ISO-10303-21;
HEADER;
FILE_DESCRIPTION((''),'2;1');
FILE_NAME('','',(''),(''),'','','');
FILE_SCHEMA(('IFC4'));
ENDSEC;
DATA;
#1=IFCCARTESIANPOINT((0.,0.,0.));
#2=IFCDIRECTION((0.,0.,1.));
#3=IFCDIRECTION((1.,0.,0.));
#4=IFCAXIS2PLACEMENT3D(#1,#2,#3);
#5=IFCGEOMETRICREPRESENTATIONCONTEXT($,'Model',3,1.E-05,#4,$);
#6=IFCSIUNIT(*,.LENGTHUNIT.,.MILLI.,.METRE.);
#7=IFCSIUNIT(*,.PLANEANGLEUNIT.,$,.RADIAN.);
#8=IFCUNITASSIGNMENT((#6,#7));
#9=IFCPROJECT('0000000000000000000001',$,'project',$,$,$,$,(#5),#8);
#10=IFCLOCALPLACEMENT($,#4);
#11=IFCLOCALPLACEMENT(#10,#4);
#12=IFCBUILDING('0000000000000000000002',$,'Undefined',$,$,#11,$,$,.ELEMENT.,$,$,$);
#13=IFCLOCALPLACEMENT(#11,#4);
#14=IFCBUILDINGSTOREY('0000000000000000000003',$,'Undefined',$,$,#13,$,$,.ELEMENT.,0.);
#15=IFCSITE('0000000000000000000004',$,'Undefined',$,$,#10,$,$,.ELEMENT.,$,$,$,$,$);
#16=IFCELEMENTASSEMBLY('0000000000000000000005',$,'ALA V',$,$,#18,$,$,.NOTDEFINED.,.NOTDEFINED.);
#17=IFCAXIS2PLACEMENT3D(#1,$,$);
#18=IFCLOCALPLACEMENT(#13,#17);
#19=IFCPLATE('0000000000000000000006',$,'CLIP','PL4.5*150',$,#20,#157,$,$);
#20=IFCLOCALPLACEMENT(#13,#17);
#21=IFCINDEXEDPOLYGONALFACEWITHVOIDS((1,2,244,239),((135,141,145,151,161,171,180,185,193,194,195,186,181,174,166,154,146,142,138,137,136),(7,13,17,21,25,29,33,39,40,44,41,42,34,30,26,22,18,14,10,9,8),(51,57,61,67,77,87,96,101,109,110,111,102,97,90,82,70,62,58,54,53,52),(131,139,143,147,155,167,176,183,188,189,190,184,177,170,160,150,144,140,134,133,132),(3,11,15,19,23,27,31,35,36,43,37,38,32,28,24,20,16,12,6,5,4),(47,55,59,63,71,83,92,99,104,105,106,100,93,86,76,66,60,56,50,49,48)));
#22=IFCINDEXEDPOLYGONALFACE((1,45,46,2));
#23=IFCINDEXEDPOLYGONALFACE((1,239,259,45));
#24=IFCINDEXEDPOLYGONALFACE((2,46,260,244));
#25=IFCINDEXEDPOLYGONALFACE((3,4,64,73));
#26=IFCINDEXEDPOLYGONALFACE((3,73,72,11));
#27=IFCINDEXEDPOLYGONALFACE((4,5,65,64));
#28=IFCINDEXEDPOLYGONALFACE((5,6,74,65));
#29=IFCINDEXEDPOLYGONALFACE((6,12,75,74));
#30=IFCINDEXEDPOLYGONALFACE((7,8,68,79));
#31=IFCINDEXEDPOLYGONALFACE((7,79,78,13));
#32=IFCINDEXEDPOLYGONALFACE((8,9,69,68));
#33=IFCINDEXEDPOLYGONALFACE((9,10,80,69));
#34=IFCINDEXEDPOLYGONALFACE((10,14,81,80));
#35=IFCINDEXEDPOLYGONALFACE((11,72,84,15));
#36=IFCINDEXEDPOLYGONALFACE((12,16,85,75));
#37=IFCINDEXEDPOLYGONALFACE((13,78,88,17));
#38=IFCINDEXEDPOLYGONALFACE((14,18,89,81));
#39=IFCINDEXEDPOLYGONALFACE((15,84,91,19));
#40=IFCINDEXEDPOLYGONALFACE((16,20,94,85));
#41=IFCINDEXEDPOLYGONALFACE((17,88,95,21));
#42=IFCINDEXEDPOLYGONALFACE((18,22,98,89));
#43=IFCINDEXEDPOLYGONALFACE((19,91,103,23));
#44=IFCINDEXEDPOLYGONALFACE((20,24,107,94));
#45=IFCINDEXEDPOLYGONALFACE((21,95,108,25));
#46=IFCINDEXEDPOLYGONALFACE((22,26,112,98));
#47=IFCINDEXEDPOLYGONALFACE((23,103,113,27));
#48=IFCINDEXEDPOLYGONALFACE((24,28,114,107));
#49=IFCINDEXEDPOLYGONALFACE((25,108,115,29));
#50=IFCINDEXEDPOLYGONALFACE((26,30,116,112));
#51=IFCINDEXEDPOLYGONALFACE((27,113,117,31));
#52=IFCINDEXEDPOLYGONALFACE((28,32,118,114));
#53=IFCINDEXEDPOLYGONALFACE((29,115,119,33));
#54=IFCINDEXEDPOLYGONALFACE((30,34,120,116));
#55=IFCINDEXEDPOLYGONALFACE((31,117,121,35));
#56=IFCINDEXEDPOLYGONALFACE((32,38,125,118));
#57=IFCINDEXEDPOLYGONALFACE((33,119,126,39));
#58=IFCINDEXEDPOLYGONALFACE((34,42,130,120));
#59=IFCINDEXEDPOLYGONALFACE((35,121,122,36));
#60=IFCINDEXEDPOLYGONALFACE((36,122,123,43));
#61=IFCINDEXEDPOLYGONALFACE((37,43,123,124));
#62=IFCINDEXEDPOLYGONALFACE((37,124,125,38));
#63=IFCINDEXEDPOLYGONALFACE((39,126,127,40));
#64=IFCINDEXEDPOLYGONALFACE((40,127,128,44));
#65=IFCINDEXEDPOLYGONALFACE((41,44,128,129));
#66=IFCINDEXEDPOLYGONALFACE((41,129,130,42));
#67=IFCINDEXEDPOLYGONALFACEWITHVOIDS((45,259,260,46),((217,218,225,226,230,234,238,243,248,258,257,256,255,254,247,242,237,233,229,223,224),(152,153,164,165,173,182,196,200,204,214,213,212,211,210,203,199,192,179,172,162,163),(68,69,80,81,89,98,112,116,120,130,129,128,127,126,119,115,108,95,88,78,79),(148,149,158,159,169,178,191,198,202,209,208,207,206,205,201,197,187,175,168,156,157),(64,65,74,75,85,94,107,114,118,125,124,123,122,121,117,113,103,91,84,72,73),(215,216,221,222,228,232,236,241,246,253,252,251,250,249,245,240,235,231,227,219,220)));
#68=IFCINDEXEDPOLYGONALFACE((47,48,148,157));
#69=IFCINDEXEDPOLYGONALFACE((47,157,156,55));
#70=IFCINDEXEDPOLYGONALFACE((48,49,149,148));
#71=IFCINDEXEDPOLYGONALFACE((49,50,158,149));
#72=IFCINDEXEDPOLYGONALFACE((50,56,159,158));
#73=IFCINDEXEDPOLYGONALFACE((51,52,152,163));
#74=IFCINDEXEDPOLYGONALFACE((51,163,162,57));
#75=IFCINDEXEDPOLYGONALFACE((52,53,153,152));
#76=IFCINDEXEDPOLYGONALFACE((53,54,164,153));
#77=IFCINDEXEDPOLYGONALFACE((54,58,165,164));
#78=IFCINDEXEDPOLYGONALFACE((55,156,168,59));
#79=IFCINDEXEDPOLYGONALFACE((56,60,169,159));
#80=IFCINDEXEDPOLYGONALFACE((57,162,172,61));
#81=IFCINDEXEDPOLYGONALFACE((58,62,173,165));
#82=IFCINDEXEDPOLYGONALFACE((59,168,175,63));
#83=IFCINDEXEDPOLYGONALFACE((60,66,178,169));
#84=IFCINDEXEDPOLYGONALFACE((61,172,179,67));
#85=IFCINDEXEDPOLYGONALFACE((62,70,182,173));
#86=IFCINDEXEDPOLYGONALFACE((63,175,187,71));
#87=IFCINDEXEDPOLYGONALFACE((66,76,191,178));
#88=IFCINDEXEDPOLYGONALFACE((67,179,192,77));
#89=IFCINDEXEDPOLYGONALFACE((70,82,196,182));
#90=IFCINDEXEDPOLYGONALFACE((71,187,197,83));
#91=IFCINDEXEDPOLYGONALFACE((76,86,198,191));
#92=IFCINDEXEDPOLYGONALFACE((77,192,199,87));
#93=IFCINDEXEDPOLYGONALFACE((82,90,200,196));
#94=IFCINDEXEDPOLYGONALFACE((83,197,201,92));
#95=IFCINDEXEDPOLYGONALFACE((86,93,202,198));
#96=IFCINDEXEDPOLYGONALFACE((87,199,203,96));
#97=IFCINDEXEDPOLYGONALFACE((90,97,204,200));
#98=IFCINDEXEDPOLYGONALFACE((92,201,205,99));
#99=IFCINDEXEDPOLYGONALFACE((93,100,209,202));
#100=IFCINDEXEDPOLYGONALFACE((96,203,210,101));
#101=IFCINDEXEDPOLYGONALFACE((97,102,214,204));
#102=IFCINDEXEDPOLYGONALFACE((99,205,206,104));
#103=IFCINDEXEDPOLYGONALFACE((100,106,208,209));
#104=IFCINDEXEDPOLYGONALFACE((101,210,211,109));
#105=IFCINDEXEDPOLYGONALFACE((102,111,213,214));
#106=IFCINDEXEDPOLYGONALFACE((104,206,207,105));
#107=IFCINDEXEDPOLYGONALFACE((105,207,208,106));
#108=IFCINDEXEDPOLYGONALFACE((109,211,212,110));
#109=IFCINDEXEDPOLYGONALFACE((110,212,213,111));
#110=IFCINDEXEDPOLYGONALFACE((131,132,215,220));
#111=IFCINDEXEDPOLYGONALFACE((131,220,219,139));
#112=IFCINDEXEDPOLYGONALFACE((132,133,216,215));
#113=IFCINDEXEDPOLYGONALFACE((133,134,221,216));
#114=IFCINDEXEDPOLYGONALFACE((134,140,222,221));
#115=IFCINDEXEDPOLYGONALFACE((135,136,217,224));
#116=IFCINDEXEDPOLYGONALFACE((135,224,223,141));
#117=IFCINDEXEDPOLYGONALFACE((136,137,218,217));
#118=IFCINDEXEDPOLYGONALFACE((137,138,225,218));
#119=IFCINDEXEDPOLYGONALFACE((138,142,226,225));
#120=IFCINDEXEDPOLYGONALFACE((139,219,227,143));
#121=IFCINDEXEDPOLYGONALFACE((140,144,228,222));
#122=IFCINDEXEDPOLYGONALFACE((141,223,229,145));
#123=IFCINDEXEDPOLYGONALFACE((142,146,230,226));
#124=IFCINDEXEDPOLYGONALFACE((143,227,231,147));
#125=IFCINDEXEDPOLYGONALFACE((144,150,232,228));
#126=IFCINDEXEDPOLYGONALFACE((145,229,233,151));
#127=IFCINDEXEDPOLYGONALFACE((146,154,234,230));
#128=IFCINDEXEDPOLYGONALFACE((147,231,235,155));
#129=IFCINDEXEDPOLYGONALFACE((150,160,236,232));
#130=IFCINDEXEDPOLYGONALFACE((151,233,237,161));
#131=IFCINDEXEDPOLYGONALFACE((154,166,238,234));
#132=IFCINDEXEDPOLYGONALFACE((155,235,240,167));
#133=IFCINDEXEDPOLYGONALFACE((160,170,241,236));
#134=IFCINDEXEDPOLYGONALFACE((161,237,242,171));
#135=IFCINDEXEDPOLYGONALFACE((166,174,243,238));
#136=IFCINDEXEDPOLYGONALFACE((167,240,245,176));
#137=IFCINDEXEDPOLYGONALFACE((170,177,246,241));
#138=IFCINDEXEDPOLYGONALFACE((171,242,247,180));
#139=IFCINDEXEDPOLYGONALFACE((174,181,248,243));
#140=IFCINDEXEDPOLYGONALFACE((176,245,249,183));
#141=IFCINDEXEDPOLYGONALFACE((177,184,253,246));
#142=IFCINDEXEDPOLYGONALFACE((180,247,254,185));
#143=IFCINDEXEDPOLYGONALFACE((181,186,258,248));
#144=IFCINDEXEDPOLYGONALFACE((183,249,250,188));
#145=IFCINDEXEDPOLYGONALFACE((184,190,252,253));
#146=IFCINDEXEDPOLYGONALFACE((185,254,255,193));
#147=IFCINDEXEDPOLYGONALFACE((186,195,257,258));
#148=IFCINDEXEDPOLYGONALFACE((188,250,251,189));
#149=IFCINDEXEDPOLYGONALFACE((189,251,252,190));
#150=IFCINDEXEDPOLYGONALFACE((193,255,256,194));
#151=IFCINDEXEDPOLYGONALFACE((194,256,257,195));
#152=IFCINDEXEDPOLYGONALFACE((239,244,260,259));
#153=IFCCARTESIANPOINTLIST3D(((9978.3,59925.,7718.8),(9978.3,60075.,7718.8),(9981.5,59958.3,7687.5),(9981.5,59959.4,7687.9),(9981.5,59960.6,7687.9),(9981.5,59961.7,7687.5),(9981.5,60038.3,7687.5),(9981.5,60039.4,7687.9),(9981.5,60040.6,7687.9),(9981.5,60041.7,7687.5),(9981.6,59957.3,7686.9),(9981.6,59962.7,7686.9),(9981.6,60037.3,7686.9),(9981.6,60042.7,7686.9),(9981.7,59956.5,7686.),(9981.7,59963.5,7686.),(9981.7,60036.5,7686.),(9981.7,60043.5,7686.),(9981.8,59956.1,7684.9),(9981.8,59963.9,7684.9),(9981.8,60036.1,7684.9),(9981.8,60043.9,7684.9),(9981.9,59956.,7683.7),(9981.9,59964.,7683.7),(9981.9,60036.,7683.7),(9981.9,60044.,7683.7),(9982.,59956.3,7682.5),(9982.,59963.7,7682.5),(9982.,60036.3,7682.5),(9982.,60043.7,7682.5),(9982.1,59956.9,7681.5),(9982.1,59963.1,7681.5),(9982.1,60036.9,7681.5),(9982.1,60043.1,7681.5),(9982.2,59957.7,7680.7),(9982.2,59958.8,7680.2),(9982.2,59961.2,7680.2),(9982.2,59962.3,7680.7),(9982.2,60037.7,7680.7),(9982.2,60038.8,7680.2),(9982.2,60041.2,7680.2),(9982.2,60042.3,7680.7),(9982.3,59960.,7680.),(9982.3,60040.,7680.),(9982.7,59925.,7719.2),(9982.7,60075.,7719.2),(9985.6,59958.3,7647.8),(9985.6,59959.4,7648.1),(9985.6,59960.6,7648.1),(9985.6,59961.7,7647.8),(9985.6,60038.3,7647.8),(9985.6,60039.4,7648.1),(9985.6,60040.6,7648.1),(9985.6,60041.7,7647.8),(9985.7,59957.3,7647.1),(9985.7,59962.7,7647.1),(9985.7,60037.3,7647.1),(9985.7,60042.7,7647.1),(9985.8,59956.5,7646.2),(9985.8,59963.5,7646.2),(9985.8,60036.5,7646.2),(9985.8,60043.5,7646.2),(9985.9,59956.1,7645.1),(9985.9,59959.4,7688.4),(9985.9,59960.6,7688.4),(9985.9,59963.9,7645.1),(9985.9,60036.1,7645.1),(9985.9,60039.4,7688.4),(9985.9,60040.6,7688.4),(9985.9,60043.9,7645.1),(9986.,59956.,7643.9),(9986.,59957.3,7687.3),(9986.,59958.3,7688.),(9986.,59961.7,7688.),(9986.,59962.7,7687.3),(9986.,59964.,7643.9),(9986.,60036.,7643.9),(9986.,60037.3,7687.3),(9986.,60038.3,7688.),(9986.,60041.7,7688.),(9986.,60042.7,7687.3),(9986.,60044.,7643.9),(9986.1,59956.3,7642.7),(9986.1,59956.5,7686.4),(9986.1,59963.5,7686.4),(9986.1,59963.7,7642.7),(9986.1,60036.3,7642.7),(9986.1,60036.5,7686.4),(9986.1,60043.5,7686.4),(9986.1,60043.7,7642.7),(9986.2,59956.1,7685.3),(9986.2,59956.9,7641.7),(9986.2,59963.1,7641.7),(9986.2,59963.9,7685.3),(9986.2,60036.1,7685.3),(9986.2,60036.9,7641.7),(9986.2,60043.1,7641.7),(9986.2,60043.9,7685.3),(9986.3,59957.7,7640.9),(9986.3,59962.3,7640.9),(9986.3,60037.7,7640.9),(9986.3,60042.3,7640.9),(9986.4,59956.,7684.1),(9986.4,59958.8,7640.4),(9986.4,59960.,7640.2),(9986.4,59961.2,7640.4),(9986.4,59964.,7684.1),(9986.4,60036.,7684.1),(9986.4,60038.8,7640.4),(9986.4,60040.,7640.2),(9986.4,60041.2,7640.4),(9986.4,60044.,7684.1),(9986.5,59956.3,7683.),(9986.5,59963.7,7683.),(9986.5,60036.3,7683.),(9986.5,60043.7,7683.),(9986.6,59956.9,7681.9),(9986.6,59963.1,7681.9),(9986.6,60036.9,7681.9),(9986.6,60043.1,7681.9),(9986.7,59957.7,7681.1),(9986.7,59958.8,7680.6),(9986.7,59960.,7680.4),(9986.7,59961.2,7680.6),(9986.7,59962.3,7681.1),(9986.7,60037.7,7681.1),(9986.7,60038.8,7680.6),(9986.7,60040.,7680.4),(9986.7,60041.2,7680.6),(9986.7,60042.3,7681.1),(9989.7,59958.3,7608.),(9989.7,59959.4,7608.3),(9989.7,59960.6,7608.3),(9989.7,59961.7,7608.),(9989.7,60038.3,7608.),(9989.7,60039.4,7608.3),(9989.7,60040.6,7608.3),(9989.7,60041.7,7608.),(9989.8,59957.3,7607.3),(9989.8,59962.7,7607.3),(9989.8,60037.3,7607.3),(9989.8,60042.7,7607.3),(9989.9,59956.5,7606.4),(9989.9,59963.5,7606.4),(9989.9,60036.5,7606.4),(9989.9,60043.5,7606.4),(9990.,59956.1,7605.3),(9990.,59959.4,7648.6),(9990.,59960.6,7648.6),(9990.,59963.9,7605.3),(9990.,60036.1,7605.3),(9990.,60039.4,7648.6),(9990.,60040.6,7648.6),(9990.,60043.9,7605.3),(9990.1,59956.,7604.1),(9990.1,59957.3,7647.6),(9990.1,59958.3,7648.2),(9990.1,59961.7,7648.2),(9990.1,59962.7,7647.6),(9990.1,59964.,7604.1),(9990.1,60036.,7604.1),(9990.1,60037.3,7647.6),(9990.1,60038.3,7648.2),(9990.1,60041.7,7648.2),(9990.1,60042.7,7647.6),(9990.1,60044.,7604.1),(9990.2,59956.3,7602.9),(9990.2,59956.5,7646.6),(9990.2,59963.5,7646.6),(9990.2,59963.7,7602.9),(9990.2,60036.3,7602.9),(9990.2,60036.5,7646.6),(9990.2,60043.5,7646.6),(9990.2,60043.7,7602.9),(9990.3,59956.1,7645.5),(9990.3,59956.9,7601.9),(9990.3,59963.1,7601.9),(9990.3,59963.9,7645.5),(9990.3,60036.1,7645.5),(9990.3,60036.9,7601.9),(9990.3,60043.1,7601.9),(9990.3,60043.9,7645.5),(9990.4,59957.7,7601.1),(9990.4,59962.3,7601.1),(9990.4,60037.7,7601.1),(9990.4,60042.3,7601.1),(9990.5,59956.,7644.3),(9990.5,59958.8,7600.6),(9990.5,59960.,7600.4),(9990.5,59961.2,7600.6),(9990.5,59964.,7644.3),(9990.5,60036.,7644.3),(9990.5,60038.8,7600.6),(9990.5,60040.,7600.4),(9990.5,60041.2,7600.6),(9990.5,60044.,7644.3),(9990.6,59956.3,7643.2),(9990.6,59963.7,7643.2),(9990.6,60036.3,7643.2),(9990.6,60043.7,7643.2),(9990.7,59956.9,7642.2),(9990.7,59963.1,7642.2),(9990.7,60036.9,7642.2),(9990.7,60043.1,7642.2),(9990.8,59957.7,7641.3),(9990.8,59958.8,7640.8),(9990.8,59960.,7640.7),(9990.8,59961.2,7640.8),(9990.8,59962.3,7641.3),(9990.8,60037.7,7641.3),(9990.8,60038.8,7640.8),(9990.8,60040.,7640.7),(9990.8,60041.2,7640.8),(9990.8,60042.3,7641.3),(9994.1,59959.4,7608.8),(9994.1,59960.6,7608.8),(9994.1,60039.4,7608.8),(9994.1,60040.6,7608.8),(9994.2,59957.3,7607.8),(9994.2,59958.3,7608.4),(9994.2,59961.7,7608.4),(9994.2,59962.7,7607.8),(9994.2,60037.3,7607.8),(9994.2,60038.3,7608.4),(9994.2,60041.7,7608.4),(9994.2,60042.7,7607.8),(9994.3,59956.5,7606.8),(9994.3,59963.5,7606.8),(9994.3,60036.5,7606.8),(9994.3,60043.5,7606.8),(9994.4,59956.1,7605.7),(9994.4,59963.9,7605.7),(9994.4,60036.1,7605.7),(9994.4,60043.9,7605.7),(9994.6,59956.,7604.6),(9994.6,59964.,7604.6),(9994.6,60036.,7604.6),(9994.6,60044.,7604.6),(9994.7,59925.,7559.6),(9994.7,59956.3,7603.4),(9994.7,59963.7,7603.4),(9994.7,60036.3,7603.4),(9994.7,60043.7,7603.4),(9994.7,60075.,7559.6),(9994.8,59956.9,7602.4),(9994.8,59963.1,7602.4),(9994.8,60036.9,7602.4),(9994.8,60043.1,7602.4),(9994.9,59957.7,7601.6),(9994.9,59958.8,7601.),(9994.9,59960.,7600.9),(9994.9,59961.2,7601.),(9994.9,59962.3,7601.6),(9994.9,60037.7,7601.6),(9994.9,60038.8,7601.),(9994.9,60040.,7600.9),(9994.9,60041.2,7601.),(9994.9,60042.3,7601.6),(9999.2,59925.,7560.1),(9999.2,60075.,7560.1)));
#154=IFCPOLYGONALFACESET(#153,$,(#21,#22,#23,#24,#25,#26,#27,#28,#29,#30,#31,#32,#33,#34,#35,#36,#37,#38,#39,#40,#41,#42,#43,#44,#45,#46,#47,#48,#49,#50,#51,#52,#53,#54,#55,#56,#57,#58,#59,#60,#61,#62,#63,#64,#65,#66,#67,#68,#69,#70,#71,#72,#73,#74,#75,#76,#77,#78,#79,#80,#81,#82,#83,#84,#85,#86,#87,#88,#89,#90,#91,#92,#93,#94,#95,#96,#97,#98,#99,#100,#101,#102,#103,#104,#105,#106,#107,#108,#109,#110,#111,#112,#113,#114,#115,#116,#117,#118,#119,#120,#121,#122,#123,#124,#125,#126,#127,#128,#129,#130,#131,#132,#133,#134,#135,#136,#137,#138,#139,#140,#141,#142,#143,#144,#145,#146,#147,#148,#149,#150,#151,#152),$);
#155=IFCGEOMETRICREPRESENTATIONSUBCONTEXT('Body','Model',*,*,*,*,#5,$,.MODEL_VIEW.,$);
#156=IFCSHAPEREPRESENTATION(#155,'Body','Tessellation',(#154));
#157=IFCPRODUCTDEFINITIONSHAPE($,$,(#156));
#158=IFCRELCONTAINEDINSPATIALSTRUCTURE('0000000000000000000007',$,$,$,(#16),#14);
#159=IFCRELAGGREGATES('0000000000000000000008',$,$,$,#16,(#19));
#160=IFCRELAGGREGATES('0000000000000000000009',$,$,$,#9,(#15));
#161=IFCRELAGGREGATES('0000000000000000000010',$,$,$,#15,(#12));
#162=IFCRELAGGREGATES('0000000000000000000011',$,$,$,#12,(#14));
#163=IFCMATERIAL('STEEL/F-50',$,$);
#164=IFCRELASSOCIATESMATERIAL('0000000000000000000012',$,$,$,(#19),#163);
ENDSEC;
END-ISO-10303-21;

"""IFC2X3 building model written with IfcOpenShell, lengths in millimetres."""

from ifc_helpers import new_model, si_unit, frame, origin_with_axes, origin_2d_with_axis, place, context, subcontext, project, spatial, polyline, circle, outline, extrude, source, transform, mapped, material, element, aggregate, save


model = new_model("IFC2X3")

# Units and contexts
model_context = context("Model", 3, precision=1e-05, world=origin_with_axes())
body_context = subcontext(model_context, "Body", "Model", "MODEL_VIEW")
ifc_project = project(units=[si_unit("LENGTHUNIT", "METRE", prefix="MILLI"), si_unit("PLANEANGLEUNIT", "RADIAN")], contexts=[model_context])

# Site, building, storey
site_placement = place(None, origin_with_axes())
site = spatial("IfcSite", under=ifc_project, at=site_placement, Name="Undefined", CompositionType="ELEMENT")
building_placement = place(site_placement, origin_with_axes())
building = spatial("IfcBuilding", under=site, at=building_placement, Name="Undefined", CompositionType="ELEMENT")
storey_placement = place(building_placement, origin_with_axes())
storey = spatial("IfcBuildingStorey", under=building, at=storey_placement, Name="Undefined", CompositionType="ELEMENT", Elevation=0.0)

# Element assembly
assembly_1_placement = place(storey_placement, origin_with_axes())
assembly_1 = element("IfcElementAssembly", 1, at=assembly_1_placement, inside=storey, Name="ALA V", AssemblyPlace="NOTDEFINED", PredefinedType="NOTDEFINED")
ifc_material_1 = material(Name="STEEL/F-50")

# Plate, openings
plate_1_placement = place(assembly_1_placement, frame((9980.5, 59925.0, 7719.0), z_axis=(0.994727, 0.0, 0.102562), x_axis=(0.102562, 0.0, -0.994727)))
plate_1 = element("IfcPlate", 2, at=plate_1_placement, material=ifc_material_1, Name="CLIP", Description="PL4.5*150", context=body_context, shape_type="SweptSolid", body=[
    extrude(outline(polyline([(0.0, 0.0), (160.0, 0.0), (160.0, 150.0), (0.0, 150.0), (0.0, 0.0)])), frame((0.0, 0.0, -2.2), z_axis=(0.0, 0.0, 1.0), x_axis=(1.0, 0.0, 0.0)), (0.0, 0.0, 1.0), 4.5),
])
shared_shape_1 = source(origin_with_axes(), body_context, "Body", "SweptSolid", [
    extrude(circle(Radius=4.0, at=origin_2d_with_axis()), frame((0.0, -4.6, 0.0), z_axis=(0.0, 1.0, 0.0), x_axis=(1.0, 0.0, 0.0)), (0.0, 0.0, 1.0), 4.7),
])
opening_1_placement = place(assembly_1_placement, frame((9981.9, 60040.0, 7684.0), z_axis=(0.0, 1.0, 0.0), x_axis=(0.102562, 0.0, -0.994727)))
element("IfcOpeningElement", 3, at=opening_1_placement, cuts=plate_1, ObjectType="Opening", context=body_context, shape_type="MappedRepresentation", body=[
    mapped(shared_shape_1, transform((0.0, 0.0, 0.0))),
    mapped(shared_shape_1, transform((40.0, 0.0, 0.0))),
    mapped(shared_shape_1, transform((80.0, 0.0, 0.0))),
])
opening_2_placement = place(assembly_1_placement, frame((9981.9, 59960.0, 7684.0), z_axis=(0.0, 1.0, 0.0), x_axis=(0.102562, 0.0, -0.994727)))
element("IfcOpeningElement", 4, at=opening_2_placement, cuts=plate_1, ObjectType="Opening", context=body_context, shape_type="MappedRepresentation", body=[
    mapped(shared_shape_1, transform((0.0, 0.0, 0.0))),
    mapped(shared_shape_1, transform((40.0, 0.0, 0.0))),
    mapped(shared_shape_1, transform((80.0, 0.0, 0.0))),
])

aggregate(assembly_1, [plate_1])

save(model, "model.ifc")
